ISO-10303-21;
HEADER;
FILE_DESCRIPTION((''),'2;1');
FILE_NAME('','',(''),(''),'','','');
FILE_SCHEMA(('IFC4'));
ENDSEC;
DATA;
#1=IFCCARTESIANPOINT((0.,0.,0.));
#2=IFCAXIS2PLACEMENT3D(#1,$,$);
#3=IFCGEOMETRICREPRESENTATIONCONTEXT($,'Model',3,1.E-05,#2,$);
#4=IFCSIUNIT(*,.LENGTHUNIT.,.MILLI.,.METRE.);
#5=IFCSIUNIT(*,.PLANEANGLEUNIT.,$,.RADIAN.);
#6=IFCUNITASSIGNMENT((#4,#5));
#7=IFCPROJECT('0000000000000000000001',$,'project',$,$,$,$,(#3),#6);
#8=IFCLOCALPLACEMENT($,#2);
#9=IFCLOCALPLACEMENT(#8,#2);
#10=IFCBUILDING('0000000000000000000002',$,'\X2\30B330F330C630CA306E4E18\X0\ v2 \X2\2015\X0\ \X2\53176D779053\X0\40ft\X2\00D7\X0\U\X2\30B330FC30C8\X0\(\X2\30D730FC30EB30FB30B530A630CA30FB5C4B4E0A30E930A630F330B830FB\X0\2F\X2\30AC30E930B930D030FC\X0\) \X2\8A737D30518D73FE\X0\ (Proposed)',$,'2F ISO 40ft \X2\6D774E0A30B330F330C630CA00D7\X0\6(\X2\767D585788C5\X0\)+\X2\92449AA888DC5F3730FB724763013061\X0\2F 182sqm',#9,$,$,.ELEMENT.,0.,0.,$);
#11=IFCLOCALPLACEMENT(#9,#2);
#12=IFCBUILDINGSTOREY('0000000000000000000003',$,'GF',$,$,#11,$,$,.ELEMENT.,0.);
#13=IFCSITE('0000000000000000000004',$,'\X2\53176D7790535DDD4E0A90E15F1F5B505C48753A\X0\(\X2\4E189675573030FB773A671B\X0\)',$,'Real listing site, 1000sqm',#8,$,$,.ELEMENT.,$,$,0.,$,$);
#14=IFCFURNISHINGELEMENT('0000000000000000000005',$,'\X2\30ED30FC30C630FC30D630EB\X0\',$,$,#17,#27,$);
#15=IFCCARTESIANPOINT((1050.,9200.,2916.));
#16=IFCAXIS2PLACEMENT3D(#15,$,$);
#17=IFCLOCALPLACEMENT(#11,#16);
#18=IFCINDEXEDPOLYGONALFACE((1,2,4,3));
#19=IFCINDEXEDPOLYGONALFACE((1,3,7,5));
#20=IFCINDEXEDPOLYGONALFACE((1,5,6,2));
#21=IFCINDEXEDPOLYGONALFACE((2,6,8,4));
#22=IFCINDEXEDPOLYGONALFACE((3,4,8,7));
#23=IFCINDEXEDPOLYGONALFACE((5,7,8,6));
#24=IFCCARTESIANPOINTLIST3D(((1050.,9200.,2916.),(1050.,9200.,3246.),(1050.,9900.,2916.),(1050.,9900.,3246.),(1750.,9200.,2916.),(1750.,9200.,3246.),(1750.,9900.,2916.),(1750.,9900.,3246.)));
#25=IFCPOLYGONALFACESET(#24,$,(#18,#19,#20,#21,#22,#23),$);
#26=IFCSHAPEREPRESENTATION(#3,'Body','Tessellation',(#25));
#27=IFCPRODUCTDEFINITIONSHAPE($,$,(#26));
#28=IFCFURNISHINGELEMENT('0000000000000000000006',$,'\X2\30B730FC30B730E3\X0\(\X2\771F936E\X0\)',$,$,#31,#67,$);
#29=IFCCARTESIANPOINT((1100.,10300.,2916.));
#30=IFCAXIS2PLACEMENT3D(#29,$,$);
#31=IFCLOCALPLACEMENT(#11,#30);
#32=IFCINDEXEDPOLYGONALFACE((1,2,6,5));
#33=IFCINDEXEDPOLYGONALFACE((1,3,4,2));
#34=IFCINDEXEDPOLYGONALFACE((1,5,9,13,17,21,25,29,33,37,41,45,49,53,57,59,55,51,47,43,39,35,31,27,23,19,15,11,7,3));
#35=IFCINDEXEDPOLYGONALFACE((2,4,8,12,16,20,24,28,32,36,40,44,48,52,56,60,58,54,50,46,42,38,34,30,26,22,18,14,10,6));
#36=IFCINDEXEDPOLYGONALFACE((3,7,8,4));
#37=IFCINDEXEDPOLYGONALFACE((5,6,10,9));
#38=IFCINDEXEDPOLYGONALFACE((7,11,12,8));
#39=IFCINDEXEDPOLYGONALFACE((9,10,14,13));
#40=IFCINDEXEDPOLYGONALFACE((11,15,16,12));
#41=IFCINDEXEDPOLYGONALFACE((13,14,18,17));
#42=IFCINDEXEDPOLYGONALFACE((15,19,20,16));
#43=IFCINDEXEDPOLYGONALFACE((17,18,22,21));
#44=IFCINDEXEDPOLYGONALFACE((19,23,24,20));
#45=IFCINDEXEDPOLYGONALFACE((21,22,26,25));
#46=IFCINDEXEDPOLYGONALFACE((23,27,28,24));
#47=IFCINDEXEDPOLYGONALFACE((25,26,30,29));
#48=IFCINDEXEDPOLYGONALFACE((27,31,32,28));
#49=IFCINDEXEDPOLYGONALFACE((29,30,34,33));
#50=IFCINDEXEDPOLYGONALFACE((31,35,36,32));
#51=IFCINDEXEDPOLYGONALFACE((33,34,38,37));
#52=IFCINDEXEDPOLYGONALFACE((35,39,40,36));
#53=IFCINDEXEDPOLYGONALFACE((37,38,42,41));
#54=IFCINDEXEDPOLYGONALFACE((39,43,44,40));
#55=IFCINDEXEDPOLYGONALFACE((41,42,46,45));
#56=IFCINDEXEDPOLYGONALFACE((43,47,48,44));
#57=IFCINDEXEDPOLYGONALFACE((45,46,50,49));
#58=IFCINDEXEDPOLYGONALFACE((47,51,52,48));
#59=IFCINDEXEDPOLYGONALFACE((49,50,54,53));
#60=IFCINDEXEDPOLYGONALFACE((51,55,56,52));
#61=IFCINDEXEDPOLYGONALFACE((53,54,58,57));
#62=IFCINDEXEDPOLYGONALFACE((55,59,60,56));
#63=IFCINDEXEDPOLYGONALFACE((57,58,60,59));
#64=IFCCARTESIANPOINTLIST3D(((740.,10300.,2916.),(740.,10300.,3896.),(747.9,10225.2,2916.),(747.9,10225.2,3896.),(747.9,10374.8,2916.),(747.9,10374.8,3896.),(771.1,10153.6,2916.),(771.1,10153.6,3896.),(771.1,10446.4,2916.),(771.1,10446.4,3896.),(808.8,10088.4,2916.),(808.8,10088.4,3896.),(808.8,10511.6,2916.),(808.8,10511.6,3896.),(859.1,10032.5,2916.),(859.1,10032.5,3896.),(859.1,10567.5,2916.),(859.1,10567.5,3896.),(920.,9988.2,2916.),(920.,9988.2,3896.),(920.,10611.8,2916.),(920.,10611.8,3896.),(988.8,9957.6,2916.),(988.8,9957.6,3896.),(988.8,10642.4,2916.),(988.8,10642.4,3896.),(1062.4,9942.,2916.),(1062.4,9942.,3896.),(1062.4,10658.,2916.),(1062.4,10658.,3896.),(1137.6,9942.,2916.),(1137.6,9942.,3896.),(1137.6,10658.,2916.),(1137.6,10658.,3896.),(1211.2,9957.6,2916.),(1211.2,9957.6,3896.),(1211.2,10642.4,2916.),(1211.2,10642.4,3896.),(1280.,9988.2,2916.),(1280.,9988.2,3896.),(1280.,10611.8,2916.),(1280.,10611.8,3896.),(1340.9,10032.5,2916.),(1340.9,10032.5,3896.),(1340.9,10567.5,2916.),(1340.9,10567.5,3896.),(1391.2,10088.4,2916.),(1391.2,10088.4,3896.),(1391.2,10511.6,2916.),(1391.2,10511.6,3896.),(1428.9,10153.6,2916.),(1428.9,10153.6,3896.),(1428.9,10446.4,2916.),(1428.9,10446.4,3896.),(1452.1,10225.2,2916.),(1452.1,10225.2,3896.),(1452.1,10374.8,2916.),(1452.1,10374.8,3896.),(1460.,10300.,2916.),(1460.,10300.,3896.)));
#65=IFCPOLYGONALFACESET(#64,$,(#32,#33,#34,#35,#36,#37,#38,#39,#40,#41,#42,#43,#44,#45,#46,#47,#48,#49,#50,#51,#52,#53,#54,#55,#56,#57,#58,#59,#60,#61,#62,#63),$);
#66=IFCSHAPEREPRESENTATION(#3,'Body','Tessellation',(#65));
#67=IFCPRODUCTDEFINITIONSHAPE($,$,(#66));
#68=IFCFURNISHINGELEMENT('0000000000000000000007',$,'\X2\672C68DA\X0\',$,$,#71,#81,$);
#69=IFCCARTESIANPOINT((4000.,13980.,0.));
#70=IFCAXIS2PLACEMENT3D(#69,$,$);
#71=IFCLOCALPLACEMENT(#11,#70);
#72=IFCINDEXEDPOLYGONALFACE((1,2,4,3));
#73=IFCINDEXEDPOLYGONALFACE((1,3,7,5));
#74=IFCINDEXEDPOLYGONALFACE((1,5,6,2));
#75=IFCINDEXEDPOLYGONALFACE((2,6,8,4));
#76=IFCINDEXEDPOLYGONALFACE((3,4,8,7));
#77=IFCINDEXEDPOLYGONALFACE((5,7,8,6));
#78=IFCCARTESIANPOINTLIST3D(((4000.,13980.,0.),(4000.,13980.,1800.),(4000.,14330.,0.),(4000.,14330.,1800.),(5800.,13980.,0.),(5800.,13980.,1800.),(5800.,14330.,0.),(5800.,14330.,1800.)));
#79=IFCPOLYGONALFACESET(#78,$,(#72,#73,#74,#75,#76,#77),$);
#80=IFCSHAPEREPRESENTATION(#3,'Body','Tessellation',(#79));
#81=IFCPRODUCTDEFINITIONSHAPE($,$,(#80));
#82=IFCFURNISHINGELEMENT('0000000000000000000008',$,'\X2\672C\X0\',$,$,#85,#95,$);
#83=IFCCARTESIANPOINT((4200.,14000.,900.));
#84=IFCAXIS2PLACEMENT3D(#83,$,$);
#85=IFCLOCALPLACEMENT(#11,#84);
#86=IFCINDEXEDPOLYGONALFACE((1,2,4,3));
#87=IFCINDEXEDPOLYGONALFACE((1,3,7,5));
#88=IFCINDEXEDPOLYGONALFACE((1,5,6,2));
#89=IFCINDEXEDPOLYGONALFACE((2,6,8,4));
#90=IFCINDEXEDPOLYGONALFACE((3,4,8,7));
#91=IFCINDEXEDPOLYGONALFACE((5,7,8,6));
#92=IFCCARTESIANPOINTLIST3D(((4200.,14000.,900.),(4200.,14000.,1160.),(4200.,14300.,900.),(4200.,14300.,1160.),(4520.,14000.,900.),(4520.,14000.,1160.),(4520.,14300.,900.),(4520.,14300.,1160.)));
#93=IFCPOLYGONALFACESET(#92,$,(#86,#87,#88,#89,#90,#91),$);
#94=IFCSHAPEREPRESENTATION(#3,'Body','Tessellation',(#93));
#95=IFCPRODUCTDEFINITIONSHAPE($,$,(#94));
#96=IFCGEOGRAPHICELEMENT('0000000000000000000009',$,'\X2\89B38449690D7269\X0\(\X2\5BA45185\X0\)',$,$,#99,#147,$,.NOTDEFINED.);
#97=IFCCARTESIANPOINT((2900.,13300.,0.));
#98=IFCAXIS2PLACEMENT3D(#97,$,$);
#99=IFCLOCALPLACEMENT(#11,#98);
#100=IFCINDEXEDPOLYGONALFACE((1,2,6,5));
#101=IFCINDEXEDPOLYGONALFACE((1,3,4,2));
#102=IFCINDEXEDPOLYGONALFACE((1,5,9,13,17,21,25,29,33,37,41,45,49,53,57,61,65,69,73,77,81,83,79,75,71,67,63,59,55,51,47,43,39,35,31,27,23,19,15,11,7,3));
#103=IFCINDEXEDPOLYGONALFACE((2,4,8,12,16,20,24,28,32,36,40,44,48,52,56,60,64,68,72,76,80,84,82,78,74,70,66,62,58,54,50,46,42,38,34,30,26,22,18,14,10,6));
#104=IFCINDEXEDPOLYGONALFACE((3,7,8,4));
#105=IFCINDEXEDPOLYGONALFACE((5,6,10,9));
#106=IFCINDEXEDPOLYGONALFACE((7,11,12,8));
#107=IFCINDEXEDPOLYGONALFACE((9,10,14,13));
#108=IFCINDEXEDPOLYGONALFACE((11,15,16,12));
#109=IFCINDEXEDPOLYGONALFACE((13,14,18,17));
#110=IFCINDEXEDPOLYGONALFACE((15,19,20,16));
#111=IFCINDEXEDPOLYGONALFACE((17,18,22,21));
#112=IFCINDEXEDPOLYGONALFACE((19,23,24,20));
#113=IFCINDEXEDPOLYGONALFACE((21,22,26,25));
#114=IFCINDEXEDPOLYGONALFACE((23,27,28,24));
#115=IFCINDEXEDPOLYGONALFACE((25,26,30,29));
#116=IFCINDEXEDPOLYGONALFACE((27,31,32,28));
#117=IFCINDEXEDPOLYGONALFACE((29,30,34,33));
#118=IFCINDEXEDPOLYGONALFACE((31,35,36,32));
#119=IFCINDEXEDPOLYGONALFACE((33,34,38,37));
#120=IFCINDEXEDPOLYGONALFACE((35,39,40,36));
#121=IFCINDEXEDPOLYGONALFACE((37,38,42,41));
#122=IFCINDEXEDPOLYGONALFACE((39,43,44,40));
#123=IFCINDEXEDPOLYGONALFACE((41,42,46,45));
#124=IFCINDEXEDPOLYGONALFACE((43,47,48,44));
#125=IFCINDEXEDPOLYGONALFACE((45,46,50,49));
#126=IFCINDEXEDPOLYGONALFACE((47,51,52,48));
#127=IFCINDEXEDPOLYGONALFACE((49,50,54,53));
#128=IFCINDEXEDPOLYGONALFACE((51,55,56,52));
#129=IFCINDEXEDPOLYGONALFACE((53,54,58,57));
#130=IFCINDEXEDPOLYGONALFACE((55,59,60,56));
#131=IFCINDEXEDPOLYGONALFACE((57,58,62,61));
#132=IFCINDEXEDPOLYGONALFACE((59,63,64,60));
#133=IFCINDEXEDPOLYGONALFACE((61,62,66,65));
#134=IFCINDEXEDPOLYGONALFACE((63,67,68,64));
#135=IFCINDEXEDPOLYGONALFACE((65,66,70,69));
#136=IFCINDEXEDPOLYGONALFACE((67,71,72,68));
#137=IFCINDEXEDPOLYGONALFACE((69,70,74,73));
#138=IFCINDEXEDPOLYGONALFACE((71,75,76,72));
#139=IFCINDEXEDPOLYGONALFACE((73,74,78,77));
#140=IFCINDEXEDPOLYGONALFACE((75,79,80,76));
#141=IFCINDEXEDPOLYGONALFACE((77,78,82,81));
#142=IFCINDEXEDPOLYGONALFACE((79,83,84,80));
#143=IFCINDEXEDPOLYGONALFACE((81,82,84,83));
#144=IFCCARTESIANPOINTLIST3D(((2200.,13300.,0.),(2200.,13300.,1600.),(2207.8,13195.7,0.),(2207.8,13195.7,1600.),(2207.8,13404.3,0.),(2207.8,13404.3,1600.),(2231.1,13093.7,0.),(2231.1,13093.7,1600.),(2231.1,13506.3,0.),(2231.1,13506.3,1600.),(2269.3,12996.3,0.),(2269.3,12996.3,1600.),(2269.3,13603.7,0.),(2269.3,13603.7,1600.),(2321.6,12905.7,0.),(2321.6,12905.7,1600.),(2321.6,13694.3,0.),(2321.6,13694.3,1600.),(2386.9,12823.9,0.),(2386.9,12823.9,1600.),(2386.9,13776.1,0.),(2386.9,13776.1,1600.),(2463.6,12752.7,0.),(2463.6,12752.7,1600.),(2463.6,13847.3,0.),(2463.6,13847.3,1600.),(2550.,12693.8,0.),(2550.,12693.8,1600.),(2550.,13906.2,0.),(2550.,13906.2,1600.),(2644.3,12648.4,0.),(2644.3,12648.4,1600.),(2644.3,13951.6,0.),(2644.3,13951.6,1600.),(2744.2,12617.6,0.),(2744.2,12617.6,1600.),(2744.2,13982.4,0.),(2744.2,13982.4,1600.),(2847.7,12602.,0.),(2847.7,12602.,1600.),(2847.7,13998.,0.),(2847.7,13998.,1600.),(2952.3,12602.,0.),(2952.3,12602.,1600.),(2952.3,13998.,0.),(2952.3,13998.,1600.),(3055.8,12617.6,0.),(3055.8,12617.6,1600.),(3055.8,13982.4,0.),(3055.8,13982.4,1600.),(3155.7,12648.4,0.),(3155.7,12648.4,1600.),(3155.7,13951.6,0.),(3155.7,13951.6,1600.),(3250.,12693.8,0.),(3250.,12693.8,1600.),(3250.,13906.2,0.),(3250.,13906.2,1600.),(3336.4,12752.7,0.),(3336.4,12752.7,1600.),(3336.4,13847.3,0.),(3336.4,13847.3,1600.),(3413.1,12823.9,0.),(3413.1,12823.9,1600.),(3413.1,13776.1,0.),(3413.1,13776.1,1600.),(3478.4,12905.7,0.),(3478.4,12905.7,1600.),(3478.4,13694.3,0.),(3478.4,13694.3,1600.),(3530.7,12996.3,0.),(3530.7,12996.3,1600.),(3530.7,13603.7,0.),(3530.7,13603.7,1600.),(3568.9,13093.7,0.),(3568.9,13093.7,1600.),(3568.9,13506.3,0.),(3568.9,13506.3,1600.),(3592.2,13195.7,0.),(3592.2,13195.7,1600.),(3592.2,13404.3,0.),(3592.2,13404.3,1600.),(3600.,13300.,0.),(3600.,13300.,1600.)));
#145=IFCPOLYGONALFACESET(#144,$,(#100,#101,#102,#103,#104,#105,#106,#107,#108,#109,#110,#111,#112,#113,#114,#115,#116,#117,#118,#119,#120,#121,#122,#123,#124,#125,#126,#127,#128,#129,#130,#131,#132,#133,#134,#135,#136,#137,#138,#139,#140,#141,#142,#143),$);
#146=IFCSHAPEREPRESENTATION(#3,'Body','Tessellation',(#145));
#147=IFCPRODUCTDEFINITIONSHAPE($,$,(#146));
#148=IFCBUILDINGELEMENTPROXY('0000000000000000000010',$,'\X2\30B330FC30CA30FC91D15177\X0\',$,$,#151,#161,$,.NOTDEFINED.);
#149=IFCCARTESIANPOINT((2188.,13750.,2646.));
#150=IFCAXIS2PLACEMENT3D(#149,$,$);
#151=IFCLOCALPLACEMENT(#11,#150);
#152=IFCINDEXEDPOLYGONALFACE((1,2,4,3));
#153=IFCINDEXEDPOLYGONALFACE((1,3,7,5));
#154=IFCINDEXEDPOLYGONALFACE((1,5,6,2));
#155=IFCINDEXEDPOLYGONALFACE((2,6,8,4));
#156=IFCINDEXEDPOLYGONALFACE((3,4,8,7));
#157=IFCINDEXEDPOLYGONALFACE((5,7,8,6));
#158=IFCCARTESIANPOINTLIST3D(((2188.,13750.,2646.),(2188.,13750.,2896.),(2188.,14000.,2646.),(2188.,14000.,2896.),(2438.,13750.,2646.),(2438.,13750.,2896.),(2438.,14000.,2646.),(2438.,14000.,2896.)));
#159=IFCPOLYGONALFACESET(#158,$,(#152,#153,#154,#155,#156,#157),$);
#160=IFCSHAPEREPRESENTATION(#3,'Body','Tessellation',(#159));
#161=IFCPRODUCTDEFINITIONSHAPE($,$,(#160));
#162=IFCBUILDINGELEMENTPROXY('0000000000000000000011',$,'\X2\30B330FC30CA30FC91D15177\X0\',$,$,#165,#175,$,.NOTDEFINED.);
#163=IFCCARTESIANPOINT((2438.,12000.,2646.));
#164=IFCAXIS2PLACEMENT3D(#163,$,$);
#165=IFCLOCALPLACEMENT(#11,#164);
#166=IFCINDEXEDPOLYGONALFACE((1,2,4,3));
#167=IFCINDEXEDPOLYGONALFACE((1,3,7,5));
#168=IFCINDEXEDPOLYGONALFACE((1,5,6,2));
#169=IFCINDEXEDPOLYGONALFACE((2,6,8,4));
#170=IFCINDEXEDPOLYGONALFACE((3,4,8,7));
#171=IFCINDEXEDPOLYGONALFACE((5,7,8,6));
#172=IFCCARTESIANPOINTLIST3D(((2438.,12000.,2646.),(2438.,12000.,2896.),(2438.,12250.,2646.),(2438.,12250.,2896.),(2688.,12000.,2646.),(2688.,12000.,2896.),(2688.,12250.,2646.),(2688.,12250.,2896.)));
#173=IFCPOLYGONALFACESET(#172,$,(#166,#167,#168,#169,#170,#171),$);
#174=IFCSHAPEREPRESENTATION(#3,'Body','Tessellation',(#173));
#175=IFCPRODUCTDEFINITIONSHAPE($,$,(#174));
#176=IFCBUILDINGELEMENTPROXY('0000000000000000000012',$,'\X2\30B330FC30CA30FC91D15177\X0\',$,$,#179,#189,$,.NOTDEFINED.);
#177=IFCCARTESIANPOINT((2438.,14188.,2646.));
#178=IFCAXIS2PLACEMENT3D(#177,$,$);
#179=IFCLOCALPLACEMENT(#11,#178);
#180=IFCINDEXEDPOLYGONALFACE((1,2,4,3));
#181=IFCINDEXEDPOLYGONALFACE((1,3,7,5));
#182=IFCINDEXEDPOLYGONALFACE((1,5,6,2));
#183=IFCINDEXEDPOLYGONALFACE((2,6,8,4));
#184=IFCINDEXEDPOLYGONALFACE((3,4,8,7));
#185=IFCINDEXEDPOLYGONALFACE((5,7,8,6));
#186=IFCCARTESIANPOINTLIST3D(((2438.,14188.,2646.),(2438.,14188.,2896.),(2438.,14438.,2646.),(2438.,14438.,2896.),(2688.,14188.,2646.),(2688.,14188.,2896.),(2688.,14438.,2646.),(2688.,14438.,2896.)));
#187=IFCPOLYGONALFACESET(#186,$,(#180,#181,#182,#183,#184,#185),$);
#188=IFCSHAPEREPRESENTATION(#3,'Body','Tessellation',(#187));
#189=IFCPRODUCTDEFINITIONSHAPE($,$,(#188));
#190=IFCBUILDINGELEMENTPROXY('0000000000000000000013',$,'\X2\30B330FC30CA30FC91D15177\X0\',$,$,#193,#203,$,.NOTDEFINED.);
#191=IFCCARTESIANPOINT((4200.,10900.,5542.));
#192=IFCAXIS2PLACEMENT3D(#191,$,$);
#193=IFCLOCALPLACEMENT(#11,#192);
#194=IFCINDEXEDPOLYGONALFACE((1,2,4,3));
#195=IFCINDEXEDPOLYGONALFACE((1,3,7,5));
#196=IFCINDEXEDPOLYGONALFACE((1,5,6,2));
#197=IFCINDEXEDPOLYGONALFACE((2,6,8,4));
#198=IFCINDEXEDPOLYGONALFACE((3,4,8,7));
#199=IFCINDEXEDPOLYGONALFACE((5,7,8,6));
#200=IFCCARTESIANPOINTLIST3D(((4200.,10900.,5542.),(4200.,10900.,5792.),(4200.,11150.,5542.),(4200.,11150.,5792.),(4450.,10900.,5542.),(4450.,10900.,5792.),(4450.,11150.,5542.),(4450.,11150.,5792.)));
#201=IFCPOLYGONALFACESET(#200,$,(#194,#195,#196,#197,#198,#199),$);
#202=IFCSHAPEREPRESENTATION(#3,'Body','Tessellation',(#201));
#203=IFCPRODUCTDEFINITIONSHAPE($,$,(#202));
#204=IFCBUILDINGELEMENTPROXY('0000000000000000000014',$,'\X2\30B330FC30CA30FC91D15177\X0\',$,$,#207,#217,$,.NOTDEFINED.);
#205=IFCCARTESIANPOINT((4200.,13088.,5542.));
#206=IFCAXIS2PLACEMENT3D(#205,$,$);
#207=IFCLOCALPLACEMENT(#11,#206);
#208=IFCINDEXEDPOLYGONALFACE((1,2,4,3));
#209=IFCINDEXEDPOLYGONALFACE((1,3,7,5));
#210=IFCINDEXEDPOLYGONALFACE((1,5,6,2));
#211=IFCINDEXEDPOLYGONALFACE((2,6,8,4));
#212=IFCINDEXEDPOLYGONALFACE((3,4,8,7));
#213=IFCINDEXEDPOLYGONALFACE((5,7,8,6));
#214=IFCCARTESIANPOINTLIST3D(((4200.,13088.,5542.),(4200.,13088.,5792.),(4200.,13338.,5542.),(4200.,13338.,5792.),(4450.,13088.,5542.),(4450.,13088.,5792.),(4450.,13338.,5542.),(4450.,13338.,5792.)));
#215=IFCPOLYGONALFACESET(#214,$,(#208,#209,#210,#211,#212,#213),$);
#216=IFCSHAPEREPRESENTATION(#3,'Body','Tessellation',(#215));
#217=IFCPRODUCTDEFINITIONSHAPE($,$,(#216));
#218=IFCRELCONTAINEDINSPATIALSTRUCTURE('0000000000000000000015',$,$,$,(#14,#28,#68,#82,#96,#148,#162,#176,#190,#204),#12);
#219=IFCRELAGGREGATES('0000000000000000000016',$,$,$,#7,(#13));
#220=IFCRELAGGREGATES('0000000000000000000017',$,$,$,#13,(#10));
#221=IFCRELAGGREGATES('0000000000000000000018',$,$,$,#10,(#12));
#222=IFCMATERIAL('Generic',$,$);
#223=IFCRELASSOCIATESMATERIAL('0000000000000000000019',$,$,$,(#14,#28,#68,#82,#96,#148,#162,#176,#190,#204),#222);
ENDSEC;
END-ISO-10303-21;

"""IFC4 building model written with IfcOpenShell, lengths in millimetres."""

from ifc_helpers import new_model, si_unit, frame, frame_2d, origin, origin_2d, place, context, project, spatial, rectangle, circle, extrude, material, element, save


model = new_model("IFC4")

# Units and contexts
model_context = context("Model", 3, precision=1e-05, world=origin())
ifc_project = project(units=[si_unit("LENGTHUNIT", "METRE", prefix="MILLI"), si_unit("PLANEANGLEUNIT", "RADIAN")], contexts=[model_context])

# Site, building, storey
site_placement = place(None, origin())
site = spatial("IfcSite", under=ifc_project, at=site_placement, Name="北海道川上郡弟子屈町(丘陵地・眺望)", ObjectType="Real listing site, 1000sqm", CompositionType="ELEMENT", RefElevation=0.0)
building_placement = place(site_placement, origin())
building = spatial("IfcBuilding", under=site, at=building_placement, Name="コンテナの丘 v2 ― 北海道40ft×Uコート(プール・サウナ・屋上ラウンジ・2Fガラスバー) 詳細再現 (Proposed)", ObjectType="2F ISO 40ft 海上コンテナ×6(白塗装)+鉄骨補強・片持ち2F 182sqm", CompositionType="ELEMENT", ElevationOfRefHeight=0.0, ElevationOfTerrain=0.0)
storey_placement = place(building_placement, origin())
storey = spatial("IfcBuildingStorey", under=building, at=storey_placement, Name="GF", CompositionType="ELEMENT", Elevation=0.0)

# Shared definitions
ifc_material = material(Name="Generic")

# Furnishing elements
furnishing_1_placement = place(storey_placement, frame((1050.0, 9200.0, 2916.0)))
element("IfcFurnishingElement", 1, at=furnishing_1_placement, inside=storey, material=ifc_material, Name="ローテーブル", context=model_context, shape_type="SweptSolid", body=[
    extrude(rectangle(XDim=700.0, YDim=700.0, at=frame_2d((350.0, 350.0))), frame((1050.0, 9200.0, 2916.0)), (0.0, 0.0, 1.0), 330.0),
])
furnishing_2_placement = place(storey_placement, frame((1100.0, 10300.0, 2916.0)))
element("IfcFurnishingElement", 2, at=furnishing_2_placement, inside=storey, material=ifc_material, Name="シーシャ(真鍮)", context=model_context, shape_type="SweptSolid", body=[
    extrude(circle(Radius=360.0, at=origin_2d()), frame((1100.0, 10300.0, 2916.0)), (0.0, 0.0, 1.0), 980.0),
])
furnishing_3_placement = place(storey_placement, frame((4000.0, 13980.0, 0.0)))
element("IfcFurnishingElement", 3, at=furnishing_3_placement, inside=storey, material=ifc_material, Name="本棚", context=model_context, shape_type="SweptSolid", body=[
    extrude(rectangle(XDim=1800.0, YDim=350.0, at=frame_2d((900.0, 175.0))), frame((4000.0, 13980.0, 0.0)), (0.0, 0.0, 1.0), 1800.0),
])
furnishing_4_placement = place(storey_placement, frame((4200.0, 14000.0, 900.0)))
element("IfcFurnishingElement", 4, at=furnishing_4_placement, inside=storey, material=ifc_material, Name="本", context=model_context, shape_type="SweptSolid", body=[
    extrude(rectangle(XDim=320.0, YDim=300.0, at=frame_2d((160.0, 150.0))), frame((4200.0, 14000.0, 900.0)), (0.0, 0.0, 1.0), 260.0),
])

# Geographic element
geographic_element_placement = place(storey_placement, frame((2900.0, 13300.0, 0.0)))
element("IfcGeographicElement", 5, at=geographic_element_placement, inside=storey, material=ifc_material, Name="観葉植物(室内)", PredefinedType="NOTDEFINED", context=model_context, shape_type="SweptSolid", body=[
    extrude(circle(Radius=700.0, at=origin_2d()), frame((2900.0, 13300.0, 0.0)), (0.0, 0.0, 1.0), 1600.0),
])

# Building element proxies
proxy_1_placement = place(storey_placement, frame((2188.0, 13750.0, 2646.0)))
element("IfcBuildingElementProxy", 6, at=proxy_1_placement, inside=storey, material=ifc_material, Name="コーナー金具", PredefinedType="NOTDEFINED", context=model_context, shape_type="SweptSolid", body=[
    extrude(rectangle(XDim=250.0, YDim=250.0, at=frame_2d((125.0, 125.0))), frame((2188.0, 13750.0, 2646.0)), (0.0, 0.0, 1.0), 250.0),
])
proxy_2_placement = place(storey_placement, frame((2438.0, 12000.0, 2646.0)))
element("IfcBuildingElementProxy", 7, at=proxy_2_placement, inside=storey, material=ifc_material, Name="コーナー金具", PredefinedType="NOTDEFINED", context=model_context, shape_type="SweptSolid", body=[
    extrude(rectangle(XDim=250.0, YDim=250.0, at=frame_2d((125.0, 125.0))), frame((2438.0, 12000.0, 2646.0)), (0.0, 0.0, 1.0), 250.0),
])
proxy_3_placement = place(storey_placement, frame((2438.0, 14188.0, 2646.0)))
element("IfcBuildingElementProxy", 8, at=proxy_3_placement, inside=storey, material=ifc_material, Name="コーナー金具", PredefinedType="NOTDEFINED", context=model_context, shape_type="SweptSolid", body=[
    extrude(rectangle(XDim=250.0, YDim=250.0, at=frame_2d((125.0, 125.0))), frame((2438.0, 14188.0, 2646.0)), (0.0, 0.0, 1.0), 250.0),
])
proxy_4_placement = place(storey_placement, frame((4200.0, 10900.0, 5542.0)))
element("IfcBuildingElementProxy", 9, at=proxy_4_placement, inside=storey, material=ifc_material, Name="コーナー金具", PredefinedType="NOTDEFINED", context=model_context, shape_type="SweptSolid", body=[
    extrude(rectangle(XDim=250.0, YDim=250.0, at=frame_2d((125.0, 125.0))), frame((4200.0, 10900.0, 5542.0)), (0.0, 0.0, 1.0), 250.0),
])
proxy_5_placement = place(storey_placement, frame((4200.0, 13088.0, 5542.0)))
element("IfcBuildingElementProxy", 10, at=proxy_5_placement, inside=storey, material=ifc_material, Name="コーナー金具", PredefinedType="NOTDEFINED", context=model_context, shape_type="SweptSolid", body=[
    extrude(rectangle(XDim=250.0, YDim=250.0, at=frame_2d((125.0, 125.0))), frame((4200.0, 13088.0, 5542.0)), (0.0, 0.0, 1.0), 250.0),
])

save(model, "model.ifc")
